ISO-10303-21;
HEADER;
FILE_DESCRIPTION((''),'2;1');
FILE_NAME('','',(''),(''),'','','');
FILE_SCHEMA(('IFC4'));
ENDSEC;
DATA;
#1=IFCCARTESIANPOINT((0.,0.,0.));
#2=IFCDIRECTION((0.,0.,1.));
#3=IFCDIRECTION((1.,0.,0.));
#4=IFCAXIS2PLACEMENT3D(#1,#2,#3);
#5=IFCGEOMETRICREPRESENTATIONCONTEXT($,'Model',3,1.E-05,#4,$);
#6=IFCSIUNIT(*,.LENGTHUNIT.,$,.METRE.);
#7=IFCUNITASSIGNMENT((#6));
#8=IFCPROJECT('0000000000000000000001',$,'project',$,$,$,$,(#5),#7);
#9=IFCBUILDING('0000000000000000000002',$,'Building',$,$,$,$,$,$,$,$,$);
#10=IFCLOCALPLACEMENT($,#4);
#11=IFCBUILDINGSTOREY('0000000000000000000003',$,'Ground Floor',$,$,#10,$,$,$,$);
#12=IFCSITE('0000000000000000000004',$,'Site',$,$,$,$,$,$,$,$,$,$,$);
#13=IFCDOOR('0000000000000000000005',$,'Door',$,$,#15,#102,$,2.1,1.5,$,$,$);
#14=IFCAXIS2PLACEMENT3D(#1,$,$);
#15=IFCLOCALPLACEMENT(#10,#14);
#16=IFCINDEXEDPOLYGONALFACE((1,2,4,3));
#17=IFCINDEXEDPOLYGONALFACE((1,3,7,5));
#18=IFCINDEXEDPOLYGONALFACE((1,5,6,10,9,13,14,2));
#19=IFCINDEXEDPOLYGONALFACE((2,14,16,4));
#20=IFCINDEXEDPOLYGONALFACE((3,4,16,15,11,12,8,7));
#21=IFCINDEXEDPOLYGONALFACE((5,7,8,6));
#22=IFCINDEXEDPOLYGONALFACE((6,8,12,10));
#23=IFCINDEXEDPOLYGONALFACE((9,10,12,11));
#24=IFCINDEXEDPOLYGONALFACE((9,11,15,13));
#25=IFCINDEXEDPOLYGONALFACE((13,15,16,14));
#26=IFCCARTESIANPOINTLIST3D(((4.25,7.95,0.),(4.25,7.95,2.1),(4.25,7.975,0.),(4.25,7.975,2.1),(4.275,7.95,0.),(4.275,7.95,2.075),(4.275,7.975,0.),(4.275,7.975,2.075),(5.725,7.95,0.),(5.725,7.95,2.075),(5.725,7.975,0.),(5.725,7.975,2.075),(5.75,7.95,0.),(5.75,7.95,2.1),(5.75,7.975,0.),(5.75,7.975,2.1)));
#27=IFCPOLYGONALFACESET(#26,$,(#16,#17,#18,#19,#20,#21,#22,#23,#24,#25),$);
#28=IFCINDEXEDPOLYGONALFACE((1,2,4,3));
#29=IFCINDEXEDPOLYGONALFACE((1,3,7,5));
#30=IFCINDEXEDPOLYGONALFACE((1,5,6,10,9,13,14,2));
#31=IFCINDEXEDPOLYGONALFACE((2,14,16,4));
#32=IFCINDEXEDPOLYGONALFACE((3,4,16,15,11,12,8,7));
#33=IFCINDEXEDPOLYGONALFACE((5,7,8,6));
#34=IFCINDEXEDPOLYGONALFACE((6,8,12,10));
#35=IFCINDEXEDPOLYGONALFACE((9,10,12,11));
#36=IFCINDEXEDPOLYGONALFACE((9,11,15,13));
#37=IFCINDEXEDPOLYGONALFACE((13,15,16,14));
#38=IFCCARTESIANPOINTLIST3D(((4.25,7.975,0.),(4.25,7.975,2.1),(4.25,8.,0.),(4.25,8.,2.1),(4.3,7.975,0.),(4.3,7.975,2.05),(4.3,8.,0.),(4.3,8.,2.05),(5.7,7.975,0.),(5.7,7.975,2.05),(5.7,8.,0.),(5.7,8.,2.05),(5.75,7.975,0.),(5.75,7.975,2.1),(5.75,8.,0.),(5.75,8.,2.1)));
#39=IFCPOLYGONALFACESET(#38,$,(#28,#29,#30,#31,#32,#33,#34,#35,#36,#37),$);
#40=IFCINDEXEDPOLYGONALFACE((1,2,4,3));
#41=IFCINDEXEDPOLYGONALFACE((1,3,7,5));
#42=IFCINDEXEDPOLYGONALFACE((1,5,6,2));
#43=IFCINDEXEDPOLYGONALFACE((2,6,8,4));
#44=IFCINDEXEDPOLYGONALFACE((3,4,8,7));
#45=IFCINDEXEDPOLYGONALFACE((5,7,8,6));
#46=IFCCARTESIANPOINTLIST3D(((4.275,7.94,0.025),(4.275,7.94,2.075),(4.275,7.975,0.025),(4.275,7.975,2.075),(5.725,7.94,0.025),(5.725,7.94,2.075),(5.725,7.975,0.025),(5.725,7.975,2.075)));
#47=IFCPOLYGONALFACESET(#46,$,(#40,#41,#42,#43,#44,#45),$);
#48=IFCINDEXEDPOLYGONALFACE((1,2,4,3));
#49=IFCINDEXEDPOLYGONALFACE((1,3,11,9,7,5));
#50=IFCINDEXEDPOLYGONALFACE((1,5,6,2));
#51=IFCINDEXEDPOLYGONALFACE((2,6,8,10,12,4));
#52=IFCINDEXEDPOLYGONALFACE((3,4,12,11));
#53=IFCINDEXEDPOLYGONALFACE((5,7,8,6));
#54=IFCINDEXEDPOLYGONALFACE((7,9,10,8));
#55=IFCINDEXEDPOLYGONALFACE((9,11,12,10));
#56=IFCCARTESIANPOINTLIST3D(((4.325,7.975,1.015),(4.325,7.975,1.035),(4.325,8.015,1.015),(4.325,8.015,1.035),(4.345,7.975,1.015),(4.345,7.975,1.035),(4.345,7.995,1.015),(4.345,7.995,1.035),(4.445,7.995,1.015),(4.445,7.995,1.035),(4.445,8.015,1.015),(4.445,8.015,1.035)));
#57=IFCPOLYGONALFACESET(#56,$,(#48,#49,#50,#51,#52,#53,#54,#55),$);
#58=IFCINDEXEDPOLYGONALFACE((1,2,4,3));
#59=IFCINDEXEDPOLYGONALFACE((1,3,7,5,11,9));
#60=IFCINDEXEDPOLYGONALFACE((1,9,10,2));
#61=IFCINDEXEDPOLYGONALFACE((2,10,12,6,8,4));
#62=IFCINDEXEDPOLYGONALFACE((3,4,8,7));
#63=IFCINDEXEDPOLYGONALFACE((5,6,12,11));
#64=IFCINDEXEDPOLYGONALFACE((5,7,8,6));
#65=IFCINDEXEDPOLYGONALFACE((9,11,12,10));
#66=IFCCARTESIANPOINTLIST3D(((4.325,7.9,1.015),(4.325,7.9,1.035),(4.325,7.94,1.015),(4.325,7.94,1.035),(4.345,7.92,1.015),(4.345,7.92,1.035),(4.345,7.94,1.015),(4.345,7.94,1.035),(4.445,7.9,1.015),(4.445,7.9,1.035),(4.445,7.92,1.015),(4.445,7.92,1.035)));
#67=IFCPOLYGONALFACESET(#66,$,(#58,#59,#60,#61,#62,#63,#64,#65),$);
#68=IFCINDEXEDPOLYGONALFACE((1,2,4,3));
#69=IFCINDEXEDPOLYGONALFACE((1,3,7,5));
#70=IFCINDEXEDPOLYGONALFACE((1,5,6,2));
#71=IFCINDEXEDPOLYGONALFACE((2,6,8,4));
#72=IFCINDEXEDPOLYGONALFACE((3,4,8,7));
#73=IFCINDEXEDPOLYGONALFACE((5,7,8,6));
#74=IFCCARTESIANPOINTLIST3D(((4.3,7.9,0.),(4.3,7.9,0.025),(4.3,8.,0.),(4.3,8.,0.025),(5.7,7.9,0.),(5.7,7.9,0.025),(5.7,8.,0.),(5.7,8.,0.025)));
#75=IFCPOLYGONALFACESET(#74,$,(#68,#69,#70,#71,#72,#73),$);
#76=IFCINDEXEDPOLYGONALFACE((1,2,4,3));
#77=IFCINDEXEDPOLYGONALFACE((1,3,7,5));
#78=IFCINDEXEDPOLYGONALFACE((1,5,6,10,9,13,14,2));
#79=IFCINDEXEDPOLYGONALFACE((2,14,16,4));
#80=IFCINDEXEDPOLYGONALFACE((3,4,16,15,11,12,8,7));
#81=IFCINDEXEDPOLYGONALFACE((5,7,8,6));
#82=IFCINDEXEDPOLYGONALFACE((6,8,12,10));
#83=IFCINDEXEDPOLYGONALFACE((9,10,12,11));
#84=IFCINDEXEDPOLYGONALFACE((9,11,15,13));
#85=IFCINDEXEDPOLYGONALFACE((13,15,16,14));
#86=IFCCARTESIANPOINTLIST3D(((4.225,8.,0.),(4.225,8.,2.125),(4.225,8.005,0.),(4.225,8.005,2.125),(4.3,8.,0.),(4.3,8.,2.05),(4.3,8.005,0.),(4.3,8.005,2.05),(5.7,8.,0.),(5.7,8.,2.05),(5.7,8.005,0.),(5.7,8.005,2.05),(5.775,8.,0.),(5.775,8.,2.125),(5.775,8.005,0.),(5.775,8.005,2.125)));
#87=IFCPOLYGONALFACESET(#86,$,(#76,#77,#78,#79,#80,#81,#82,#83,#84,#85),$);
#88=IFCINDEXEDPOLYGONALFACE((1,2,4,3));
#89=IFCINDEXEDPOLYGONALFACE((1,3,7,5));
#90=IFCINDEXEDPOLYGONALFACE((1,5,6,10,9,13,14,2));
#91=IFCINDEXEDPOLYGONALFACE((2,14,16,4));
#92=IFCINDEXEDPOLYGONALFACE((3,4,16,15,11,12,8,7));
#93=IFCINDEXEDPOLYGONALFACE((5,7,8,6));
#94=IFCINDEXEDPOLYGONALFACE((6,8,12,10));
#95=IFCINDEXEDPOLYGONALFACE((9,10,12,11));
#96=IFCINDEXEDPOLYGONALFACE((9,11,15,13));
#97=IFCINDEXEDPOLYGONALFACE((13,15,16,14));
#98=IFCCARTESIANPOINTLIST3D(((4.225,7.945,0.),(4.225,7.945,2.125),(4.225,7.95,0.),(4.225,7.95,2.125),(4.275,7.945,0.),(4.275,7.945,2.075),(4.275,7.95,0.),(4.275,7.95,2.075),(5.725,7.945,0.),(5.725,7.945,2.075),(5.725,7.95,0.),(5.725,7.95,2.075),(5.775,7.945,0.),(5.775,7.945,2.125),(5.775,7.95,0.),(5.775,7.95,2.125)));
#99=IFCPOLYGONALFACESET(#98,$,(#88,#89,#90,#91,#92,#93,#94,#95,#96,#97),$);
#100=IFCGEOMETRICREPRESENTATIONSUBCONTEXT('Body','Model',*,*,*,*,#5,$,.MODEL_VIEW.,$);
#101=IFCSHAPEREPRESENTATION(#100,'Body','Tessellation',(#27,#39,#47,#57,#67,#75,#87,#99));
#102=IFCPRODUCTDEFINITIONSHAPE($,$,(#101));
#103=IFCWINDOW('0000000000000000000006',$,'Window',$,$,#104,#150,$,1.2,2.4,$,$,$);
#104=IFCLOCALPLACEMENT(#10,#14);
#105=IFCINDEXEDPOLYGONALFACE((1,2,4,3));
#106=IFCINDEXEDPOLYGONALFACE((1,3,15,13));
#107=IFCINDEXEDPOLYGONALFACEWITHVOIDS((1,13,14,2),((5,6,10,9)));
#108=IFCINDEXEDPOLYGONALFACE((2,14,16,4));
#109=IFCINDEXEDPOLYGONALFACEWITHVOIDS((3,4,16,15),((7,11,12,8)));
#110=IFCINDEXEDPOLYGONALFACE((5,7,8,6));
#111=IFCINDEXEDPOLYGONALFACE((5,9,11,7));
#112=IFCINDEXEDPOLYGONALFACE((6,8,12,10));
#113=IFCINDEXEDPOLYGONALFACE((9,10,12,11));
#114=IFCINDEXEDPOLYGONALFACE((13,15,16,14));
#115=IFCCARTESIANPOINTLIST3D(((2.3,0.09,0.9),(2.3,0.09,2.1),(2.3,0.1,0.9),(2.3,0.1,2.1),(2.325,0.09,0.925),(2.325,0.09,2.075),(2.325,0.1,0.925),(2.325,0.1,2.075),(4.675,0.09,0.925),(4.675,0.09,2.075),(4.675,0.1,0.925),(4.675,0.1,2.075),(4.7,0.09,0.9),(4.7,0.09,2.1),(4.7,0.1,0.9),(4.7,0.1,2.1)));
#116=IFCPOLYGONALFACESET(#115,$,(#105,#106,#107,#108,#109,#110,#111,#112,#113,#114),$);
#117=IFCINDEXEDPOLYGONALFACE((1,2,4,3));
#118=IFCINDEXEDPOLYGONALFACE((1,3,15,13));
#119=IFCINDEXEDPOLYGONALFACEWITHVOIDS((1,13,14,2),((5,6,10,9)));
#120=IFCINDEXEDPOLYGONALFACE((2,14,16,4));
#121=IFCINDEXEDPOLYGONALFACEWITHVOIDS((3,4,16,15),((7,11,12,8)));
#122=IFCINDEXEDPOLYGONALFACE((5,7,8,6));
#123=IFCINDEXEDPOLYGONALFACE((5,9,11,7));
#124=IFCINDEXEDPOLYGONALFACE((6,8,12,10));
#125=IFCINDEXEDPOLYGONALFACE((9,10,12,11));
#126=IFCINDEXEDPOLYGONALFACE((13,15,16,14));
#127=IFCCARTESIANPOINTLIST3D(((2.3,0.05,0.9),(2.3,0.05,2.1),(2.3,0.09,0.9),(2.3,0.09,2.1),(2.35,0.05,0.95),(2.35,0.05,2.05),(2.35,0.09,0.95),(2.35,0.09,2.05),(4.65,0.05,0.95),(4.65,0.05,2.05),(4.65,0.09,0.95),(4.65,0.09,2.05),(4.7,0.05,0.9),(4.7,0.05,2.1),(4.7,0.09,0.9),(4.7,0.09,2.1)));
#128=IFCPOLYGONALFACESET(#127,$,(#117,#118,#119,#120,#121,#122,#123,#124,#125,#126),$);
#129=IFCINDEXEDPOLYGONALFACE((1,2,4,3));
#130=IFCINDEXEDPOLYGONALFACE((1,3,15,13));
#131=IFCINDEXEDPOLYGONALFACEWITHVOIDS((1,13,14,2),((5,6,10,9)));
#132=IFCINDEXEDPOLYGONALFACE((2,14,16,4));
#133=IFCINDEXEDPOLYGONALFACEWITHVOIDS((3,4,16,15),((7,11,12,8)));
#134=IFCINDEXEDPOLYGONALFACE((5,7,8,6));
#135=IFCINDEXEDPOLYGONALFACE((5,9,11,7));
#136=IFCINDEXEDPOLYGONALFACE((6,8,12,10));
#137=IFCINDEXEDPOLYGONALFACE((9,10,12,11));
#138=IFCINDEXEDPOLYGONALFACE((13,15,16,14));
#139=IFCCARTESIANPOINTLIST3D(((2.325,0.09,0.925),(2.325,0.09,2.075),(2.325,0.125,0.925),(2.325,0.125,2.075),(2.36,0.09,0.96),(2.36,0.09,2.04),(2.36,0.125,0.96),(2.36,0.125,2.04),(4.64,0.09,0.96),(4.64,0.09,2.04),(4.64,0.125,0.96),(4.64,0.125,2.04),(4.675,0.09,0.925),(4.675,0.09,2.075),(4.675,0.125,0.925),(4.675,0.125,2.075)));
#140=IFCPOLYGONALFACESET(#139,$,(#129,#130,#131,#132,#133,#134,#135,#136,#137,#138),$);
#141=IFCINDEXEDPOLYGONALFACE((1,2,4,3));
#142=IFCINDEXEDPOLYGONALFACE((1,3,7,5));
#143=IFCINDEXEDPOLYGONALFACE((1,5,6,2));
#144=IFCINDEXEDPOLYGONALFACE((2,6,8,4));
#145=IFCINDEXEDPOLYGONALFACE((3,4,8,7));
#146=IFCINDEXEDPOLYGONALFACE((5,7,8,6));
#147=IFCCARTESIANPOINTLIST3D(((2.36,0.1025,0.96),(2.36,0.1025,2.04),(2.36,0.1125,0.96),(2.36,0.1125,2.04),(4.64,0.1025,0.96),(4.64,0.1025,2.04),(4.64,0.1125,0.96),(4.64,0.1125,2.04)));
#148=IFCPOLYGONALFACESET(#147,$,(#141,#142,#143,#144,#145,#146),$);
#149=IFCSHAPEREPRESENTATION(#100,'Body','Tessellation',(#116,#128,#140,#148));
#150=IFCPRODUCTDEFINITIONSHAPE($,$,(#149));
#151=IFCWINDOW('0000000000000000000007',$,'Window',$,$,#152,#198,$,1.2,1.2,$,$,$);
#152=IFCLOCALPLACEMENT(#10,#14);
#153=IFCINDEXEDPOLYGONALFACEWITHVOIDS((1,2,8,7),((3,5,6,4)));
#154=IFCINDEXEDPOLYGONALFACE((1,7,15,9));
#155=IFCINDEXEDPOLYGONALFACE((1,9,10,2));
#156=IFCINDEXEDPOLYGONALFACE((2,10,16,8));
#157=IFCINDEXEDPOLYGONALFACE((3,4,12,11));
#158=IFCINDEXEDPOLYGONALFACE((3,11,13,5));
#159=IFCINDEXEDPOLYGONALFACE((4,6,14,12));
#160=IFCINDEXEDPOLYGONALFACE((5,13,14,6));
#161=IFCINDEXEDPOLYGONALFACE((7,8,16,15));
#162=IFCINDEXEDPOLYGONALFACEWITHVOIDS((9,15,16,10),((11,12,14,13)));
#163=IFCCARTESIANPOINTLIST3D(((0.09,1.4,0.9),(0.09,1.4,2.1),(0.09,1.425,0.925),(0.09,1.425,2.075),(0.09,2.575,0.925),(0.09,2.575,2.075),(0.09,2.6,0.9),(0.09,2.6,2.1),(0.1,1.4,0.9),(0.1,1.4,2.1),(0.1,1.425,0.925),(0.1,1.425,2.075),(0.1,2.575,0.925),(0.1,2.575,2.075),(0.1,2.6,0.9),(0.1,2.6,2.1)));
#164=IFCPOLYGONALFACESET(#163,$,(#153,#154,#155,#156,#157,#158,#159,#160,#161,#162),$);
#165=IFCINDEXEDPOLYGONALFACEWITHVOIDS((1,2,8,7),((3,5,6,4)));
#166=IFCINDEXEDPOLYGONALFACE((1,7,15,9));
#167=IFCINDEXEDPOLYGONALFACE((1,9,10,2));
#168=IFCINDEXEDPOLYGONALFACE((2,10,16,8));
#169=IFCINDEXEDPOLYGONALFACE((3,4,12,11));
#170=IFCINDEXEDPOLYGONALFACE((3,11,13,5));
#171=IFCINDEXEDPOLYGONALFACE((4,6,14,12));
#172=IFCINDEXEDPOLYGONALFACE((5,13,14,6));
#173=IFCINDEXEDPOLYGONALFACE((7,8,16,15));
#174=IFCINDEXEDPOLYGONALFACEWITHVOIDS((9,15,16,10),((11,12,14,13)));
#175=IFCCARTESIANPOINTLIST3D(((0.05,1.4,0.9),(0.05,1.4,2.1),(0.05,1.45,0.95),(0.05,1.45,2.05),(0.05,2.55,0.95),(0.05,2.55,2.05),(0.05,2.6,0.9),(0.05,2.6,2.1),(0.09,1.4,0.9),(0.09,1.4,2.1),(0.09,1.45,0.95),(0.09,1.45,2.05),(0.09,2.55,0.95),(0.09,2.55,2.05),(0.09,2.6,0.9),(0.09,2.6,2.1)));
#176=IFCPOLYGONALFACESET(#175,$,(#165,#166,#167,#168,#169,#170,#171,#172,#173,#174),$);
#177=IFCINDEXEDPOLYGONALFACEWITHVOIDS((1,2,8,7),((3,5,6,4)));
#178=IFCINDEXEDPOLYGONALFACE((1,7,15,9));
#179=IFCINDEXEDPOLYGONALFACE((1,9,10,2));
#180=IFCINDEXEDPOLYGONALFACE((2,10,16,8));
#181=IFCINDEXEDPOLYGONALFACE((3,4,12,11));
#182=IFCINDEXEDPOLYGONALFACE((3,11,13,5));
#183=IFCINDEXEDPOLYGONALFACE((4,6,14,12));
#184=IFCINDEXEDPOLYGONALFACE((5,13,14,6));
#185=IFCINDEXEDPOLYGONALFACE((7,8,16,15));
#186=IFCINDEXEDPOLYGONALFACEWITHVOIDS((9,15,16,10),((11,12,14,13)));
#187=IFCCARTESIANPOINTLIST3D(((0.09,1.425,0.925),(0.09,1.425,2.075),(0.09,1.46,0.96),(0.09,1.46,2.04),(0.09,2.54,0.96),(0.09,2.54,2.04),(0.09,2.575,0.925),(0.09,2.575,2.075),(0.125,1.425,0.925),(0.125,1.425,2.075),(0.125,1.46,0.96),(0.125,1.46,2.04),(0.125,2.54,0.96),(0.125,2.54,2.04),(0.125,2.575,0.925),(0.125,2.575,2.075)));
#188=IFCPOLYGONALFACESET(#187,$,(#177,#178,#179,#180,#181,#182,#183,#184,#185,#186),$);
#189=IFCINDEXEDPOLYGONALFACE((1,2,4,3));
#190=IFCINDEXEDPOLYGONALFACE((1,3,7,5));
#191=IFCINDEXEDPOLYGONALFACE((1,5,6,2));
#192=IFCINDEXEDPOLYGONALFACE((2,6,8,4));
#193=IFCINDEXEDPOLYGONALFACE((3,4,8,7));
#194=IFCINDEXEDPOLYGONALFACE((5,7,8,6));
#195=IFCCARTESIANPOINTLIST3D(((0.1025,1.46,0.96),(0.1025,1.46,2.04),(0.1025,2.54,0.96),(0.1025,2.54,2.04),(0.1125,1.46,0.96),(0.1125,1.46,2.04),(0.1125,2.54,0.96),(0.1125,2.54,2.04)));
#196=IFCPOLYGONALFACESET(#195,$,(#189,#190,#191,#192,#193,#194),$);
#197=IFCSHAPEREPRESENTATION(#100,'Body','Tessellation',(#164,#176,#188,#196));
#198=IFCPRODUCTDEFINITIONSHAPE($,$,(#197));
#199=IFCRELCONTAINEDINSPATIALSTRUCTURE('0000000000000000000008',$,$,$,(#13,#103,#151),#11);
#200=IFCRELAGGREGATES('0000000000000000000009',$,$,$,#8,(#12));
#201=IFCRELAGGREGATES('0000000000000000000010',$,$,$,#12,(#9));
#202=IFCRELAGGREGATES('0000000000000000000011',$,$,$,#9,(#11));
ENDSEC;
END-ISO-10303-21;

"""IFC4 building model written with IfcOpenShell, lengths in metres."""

from ifc_helpers import new_model, si_unit, frame, origin_with_axes, place, context, subcontext, project, spatial, line, indexed_curve, outline, extrude, element, save


model = new_model("IFC4")

# Units and contexts
model_context = context("Model", 3, precision=1e-05, world=origin_with_axes())
body_context = subcontext(model_context, "Body", "Model", "MODEL_VIEW")
ifc_project = project(units=[si_unit("LENGTHUNIT", "METRE")], contexts=[model_context])

# Site, building, storey
site = spatial("IfcSite", under=ifc_project, Name="Site")
building = spatial("IfcBuilding", under=site, Name="Building")
storey_placement = place(None, origin_with_axes())
storey = spatial("IfcBuildingStorey", under=building, at=storey_placement, Name="Ground Floor")

# Door
door_1_placement = place(storey_placement, frame((5.75, 8.0, 0.0), z_axis=(0.0, 0.0, 1.0), x_axis=(-1.0, 0.0, 0.0)))
element("IfcDoor", 1, at=door_1_placement, inside=storey, Name="Door", OverallHeight=2.1, OverallWidth=1.5, context=body_context, shape_type="SweptSolid", body=[
    extrude(outline(indexed_curve([(0.0, 0.0), (0.0, 2.1), (1.5, 2.1), (1.5, 0.0), (1.475, 0.0), (1.475, 2.075), (0.025, 2.075), (0.025, 0.0)], segments=[line(1, 2, 3, 4, 5, 6, 7, 8, 1)])), frame((0.0, 0.025, 0.0), z_axis=(0.0, -1.0, 0.0), x_axis=(1.0, 0.0, 0.0)), (0.0, 0.0, -1.0), 0.025),
    extrude(outline(indexed_curve([(0.0, 0.0), (0.0, 2.1), (1.5, 2.1), (1.5, 0.0), (1.45, 0.0), (1.45, 2.05), (0.05, 2.05), (0.05, 0.0)], segments=[line(1, 2, 3, 4, 5, 6, 7, 8, 1)])), frame((0.0, 0.0, 0.0), z_axis=(0.0, -1.0, 0.0), x_axis=(1.0, 0.0, 0.0)), (0.0, 0.0, -1.0), 0.025),
    extrude(outline(indexed_curve([(0.0, 0.0), (1.45, 0.0), (1.45, 0.035), (0.0, 0.035)], segments=[line(1, 2, 3, 4, 1)])), frame((0.025, 0.025, 0.025), z_axis=(0.0, 0.0, 1.0), x_axis=(1.0, 0.0, 0.0)), (0.0, 0.0, 1.0), 2.05),
    extrude(outline(indexed_curve([(0.0, 0.0), (0.0, -0.04), (-0.12, -0.04), (-0.12, -0.02), (-0.02, -0.02), (-0.02, 0.0)], segments=[line(1, 2, 3, 4, 5, 6, 1)])), frame((1.425, 0.025, 1.015), z_axis=(0.0, 0.0, 1.0), x_axis=(1.0, 0.0, 0.0)), (0.0, 0.0, 1.0), 0.02),
    extrude(outline(indexed_curve([(0.0, 0.0), (0.0, 0.04), (-0.12, 0.04), (-0.12, 0.02), (-0.02, 0.02), (-0.02, 0.0)], segments=[line(1, 2, 3, 4, 5, 6, 1)])), frame((1.425, 0.06, 1.015), z_axis=(0.0, 0.0, 1.0), x_axis=(1.0, 0.0, 0.0)), (0.0, 0.0, 1.0), 0.02),
    extrude(outline(indexed_curve([(0.0, 0.0), (1.4, 0.0), (1.4, 0.1), (0.0, 0.1)], segments=[line(1, 2, 3, 4, 1)])), frame((0.05, 0.0, 0.0), z_axis=(0.0, 0.0, 1.0), x_axis=(1.0, 0.0, 0.0)), (0.0, 0.0, 1.0), 0.025),
    extrude(outline(indexed_curve([(0.0, 0.0), (0.0, 2.125), (1.55, 2.125), (1.55, 0.0), (1.475, 0.0), (1.475, 2.05), (0.075, 2.05), (0.075, 0.0)], segments=[line(1, 2, 3, 4, 5, 6, 7, 8, 1)])), frame((-0.025, -0.005, 0.0), z_axis=(0.0, -1.0, 0.0), x_axis=(1.0, 0.0, 0.0)), (0.0, 0.0, -1.0), 0.005),
    extrude(outline(indexed_curve([(0.0, 0.0), (0.0, 2.125), (1.55, 2.125), (1.55, 0.0), (1.5, 0.0), (1.5, 2.075), (0.05, 2.075), (0.05, 0.0)], segments=[line(1, 2, 3, 4, 5, 6, 7, 8, 1)])), frame((-0.025, 0.05, 0.0), z_axis=(0.0, -1.0, 0.0), x_axis=(1.0, 0.0, 0.0)), (0.0, 0.0, -1.0), 0.005),
])

# Windows
window_1_placement = place(storey_placement, frame((2.3, 0.0, 0.9), z_axis=(0.0, 0.0, 1.0), x_axis=(1.0, 0.0, 0.0)))
element("IfcWindow", 2, at=window_1_placement, inside=storey, Name="Window", OverallHeight=1.2, OverallWidth=2.4, context=body_context, shape_type="SweptSolid", body=[
    extrude(outline(indexed_curve([(0.0, 0.0), (2.4, 0.0), (2.4, 1.2), (0.0, 1.2)], segments=[line(1, 2, 3, 4, 1)]), holes=[indexed_curve([(0.025, 0.025), (2.375, 0.025), (2.375, 1.175), (0.025, 1.175)], segments=[line(1, 2, 3, 4, 1)])]), frame((0.0, 0.09, 0.0), z_axis=(0.0, -1.0, 0.0), x_axis=(1.0, 0.0, 0.0)), (0.0, 0.0, -1.0), 0.01),
    extrude(outline(indexed_curve([(0.0, 0.0), (2.4, 0.0), (2.4, 1.2), (0.0, 1.2)], segments=[line(1, 2, 3, 4, 1)]), holes=[indexed_curve([(0.05, 0.05), (2.35, 0.05), (2.35, 1.15), (0.05, 1.15)], segments=[line(1, 2, 3, 4, 1)])]), frame((0.0, 0.05, 0.0), z_axis=(0.0, -1.0, 0.0), x_axis=(1.0, 0.0, 0.0)), (0.0, 0.0, -1.0), 0.04),
    extrude(outline(indexed_curve([(0.0, 0.0), (2.35, 0.0), (2.35, 1.15), (0.0, 1.15)], segments=[line(1, 2, 3, 4, 1)]), holes=[indexed_curve([(0.035, 0.035), (2.315, 0.035), (2.315, 1.115), (0.035, 1.115)], segments=[line(1, 2, 3, 4, 1)])]), frame((0.025, 0.09, 0.025), z_axis=(0.0, -1.0, 0.0), x_axis=(1.0, 0.0, 0.0)), (0.0, 0.0, -1.0), 0.035),
    extrude(outline(indexed_curve([(0.035, 0.035), (2.315, 0.035), (2.315, 1.115), (0.035, 1.115)], segments=[line(1, 2, 3, 4, 1)])), frame((0.025, 0.1025, 0.025), z_axis=(0.0, -1.0, 0.0), x_axis=(1.0, 0.0, 0.0)), (0.0, 0.0, -1.0), 0.01),
])
window_2_placement = place(storey_placement, frame((0.0, 2.6, 0.9), z_axis=(0.0, 0.0, 1.0), x_axis=(0.0, -1.0, 0.0)))
element("IfcWindow", 3, at=window_2_placement, inside=storey, Name="Window", OverallHeight=1.2, OverallWidth=1.2, context=body_context, shape_type="SweptSolid", body=[
    extrude(outline(indexed_curve([(0.0, 0.0), (1.2, 0.0), (1.2, 1.2), (0.0, 1.2)], segments=[line(1, 2, 3, 4, 1)]), holes=[indexed_curve([(0.025, 0.025), (1.175, 0.025), (1.175, 1.175), (0.025, 1.175)], segments=[line(1, 2, 3, 4, 1)])]), frame((0.0, 0.09, 0.0), z_axis=(0.0, -1.0, 0.0), x_axis=(1.0, 0.0, 0.0)), (0.0, 0.0, -1.0), 0.01),
    extrude(outline(indexed_curve([(0.0, 0.0), (1.2, 0.0), (1.2, 1.2), (0.0, 1.2)], segments=[line(1, 2, 3, 4, 1)]), holes=[indexed_curve([(0.05, 0.05), (1.15, 0.05), (1.15, 1.15), (0.05, 1.15)], segments=[line(1, 2, 3, 4, 1)])]), frame((0.0, 0.05, 0.0), z_axis=(0.0, -1.0, 0.0), x_axis=(1.0, 0.0, 0.0)), (0.0, 0.0, -1.0), 0.04),
    extrude(outline(indexed_curve([(0.0, 0.0), (1.15, 0.0), (1.15, 1.15), (0.0, 1.15)], segments=[line(1, 2, 3, 4, 1)]), holes=[indexed_curve([(0.035, 0.035), (1.115, 0.035), (1.115, 1.115), (0.035, 1.115)], segments=[line(1, 2, 3, 4, 1)])]), frame((0.025, 0.09, 0.025), z_axis=(0.0, -1.0, 0.0), x_axis=(1.0, 0.0, 0.0)), (0.0, 0.0, -1.0), 0.035),
    extrude(outline(indexed_curve([(0.035, 0.035), (1.115, 0.035), (1.115, 1.115), (0.035, 1.115)], segments=[line(1, 2, 3, 4, 1)])), frame((0.025, 0.1025, 0.025), z_axis=(0.0, -1.0, 0.0), x_axis=(1.0, 0.0, 0.0)), (0.0, 0.0, -1.0), 0.01),
])

save(model, "model.ifc")
